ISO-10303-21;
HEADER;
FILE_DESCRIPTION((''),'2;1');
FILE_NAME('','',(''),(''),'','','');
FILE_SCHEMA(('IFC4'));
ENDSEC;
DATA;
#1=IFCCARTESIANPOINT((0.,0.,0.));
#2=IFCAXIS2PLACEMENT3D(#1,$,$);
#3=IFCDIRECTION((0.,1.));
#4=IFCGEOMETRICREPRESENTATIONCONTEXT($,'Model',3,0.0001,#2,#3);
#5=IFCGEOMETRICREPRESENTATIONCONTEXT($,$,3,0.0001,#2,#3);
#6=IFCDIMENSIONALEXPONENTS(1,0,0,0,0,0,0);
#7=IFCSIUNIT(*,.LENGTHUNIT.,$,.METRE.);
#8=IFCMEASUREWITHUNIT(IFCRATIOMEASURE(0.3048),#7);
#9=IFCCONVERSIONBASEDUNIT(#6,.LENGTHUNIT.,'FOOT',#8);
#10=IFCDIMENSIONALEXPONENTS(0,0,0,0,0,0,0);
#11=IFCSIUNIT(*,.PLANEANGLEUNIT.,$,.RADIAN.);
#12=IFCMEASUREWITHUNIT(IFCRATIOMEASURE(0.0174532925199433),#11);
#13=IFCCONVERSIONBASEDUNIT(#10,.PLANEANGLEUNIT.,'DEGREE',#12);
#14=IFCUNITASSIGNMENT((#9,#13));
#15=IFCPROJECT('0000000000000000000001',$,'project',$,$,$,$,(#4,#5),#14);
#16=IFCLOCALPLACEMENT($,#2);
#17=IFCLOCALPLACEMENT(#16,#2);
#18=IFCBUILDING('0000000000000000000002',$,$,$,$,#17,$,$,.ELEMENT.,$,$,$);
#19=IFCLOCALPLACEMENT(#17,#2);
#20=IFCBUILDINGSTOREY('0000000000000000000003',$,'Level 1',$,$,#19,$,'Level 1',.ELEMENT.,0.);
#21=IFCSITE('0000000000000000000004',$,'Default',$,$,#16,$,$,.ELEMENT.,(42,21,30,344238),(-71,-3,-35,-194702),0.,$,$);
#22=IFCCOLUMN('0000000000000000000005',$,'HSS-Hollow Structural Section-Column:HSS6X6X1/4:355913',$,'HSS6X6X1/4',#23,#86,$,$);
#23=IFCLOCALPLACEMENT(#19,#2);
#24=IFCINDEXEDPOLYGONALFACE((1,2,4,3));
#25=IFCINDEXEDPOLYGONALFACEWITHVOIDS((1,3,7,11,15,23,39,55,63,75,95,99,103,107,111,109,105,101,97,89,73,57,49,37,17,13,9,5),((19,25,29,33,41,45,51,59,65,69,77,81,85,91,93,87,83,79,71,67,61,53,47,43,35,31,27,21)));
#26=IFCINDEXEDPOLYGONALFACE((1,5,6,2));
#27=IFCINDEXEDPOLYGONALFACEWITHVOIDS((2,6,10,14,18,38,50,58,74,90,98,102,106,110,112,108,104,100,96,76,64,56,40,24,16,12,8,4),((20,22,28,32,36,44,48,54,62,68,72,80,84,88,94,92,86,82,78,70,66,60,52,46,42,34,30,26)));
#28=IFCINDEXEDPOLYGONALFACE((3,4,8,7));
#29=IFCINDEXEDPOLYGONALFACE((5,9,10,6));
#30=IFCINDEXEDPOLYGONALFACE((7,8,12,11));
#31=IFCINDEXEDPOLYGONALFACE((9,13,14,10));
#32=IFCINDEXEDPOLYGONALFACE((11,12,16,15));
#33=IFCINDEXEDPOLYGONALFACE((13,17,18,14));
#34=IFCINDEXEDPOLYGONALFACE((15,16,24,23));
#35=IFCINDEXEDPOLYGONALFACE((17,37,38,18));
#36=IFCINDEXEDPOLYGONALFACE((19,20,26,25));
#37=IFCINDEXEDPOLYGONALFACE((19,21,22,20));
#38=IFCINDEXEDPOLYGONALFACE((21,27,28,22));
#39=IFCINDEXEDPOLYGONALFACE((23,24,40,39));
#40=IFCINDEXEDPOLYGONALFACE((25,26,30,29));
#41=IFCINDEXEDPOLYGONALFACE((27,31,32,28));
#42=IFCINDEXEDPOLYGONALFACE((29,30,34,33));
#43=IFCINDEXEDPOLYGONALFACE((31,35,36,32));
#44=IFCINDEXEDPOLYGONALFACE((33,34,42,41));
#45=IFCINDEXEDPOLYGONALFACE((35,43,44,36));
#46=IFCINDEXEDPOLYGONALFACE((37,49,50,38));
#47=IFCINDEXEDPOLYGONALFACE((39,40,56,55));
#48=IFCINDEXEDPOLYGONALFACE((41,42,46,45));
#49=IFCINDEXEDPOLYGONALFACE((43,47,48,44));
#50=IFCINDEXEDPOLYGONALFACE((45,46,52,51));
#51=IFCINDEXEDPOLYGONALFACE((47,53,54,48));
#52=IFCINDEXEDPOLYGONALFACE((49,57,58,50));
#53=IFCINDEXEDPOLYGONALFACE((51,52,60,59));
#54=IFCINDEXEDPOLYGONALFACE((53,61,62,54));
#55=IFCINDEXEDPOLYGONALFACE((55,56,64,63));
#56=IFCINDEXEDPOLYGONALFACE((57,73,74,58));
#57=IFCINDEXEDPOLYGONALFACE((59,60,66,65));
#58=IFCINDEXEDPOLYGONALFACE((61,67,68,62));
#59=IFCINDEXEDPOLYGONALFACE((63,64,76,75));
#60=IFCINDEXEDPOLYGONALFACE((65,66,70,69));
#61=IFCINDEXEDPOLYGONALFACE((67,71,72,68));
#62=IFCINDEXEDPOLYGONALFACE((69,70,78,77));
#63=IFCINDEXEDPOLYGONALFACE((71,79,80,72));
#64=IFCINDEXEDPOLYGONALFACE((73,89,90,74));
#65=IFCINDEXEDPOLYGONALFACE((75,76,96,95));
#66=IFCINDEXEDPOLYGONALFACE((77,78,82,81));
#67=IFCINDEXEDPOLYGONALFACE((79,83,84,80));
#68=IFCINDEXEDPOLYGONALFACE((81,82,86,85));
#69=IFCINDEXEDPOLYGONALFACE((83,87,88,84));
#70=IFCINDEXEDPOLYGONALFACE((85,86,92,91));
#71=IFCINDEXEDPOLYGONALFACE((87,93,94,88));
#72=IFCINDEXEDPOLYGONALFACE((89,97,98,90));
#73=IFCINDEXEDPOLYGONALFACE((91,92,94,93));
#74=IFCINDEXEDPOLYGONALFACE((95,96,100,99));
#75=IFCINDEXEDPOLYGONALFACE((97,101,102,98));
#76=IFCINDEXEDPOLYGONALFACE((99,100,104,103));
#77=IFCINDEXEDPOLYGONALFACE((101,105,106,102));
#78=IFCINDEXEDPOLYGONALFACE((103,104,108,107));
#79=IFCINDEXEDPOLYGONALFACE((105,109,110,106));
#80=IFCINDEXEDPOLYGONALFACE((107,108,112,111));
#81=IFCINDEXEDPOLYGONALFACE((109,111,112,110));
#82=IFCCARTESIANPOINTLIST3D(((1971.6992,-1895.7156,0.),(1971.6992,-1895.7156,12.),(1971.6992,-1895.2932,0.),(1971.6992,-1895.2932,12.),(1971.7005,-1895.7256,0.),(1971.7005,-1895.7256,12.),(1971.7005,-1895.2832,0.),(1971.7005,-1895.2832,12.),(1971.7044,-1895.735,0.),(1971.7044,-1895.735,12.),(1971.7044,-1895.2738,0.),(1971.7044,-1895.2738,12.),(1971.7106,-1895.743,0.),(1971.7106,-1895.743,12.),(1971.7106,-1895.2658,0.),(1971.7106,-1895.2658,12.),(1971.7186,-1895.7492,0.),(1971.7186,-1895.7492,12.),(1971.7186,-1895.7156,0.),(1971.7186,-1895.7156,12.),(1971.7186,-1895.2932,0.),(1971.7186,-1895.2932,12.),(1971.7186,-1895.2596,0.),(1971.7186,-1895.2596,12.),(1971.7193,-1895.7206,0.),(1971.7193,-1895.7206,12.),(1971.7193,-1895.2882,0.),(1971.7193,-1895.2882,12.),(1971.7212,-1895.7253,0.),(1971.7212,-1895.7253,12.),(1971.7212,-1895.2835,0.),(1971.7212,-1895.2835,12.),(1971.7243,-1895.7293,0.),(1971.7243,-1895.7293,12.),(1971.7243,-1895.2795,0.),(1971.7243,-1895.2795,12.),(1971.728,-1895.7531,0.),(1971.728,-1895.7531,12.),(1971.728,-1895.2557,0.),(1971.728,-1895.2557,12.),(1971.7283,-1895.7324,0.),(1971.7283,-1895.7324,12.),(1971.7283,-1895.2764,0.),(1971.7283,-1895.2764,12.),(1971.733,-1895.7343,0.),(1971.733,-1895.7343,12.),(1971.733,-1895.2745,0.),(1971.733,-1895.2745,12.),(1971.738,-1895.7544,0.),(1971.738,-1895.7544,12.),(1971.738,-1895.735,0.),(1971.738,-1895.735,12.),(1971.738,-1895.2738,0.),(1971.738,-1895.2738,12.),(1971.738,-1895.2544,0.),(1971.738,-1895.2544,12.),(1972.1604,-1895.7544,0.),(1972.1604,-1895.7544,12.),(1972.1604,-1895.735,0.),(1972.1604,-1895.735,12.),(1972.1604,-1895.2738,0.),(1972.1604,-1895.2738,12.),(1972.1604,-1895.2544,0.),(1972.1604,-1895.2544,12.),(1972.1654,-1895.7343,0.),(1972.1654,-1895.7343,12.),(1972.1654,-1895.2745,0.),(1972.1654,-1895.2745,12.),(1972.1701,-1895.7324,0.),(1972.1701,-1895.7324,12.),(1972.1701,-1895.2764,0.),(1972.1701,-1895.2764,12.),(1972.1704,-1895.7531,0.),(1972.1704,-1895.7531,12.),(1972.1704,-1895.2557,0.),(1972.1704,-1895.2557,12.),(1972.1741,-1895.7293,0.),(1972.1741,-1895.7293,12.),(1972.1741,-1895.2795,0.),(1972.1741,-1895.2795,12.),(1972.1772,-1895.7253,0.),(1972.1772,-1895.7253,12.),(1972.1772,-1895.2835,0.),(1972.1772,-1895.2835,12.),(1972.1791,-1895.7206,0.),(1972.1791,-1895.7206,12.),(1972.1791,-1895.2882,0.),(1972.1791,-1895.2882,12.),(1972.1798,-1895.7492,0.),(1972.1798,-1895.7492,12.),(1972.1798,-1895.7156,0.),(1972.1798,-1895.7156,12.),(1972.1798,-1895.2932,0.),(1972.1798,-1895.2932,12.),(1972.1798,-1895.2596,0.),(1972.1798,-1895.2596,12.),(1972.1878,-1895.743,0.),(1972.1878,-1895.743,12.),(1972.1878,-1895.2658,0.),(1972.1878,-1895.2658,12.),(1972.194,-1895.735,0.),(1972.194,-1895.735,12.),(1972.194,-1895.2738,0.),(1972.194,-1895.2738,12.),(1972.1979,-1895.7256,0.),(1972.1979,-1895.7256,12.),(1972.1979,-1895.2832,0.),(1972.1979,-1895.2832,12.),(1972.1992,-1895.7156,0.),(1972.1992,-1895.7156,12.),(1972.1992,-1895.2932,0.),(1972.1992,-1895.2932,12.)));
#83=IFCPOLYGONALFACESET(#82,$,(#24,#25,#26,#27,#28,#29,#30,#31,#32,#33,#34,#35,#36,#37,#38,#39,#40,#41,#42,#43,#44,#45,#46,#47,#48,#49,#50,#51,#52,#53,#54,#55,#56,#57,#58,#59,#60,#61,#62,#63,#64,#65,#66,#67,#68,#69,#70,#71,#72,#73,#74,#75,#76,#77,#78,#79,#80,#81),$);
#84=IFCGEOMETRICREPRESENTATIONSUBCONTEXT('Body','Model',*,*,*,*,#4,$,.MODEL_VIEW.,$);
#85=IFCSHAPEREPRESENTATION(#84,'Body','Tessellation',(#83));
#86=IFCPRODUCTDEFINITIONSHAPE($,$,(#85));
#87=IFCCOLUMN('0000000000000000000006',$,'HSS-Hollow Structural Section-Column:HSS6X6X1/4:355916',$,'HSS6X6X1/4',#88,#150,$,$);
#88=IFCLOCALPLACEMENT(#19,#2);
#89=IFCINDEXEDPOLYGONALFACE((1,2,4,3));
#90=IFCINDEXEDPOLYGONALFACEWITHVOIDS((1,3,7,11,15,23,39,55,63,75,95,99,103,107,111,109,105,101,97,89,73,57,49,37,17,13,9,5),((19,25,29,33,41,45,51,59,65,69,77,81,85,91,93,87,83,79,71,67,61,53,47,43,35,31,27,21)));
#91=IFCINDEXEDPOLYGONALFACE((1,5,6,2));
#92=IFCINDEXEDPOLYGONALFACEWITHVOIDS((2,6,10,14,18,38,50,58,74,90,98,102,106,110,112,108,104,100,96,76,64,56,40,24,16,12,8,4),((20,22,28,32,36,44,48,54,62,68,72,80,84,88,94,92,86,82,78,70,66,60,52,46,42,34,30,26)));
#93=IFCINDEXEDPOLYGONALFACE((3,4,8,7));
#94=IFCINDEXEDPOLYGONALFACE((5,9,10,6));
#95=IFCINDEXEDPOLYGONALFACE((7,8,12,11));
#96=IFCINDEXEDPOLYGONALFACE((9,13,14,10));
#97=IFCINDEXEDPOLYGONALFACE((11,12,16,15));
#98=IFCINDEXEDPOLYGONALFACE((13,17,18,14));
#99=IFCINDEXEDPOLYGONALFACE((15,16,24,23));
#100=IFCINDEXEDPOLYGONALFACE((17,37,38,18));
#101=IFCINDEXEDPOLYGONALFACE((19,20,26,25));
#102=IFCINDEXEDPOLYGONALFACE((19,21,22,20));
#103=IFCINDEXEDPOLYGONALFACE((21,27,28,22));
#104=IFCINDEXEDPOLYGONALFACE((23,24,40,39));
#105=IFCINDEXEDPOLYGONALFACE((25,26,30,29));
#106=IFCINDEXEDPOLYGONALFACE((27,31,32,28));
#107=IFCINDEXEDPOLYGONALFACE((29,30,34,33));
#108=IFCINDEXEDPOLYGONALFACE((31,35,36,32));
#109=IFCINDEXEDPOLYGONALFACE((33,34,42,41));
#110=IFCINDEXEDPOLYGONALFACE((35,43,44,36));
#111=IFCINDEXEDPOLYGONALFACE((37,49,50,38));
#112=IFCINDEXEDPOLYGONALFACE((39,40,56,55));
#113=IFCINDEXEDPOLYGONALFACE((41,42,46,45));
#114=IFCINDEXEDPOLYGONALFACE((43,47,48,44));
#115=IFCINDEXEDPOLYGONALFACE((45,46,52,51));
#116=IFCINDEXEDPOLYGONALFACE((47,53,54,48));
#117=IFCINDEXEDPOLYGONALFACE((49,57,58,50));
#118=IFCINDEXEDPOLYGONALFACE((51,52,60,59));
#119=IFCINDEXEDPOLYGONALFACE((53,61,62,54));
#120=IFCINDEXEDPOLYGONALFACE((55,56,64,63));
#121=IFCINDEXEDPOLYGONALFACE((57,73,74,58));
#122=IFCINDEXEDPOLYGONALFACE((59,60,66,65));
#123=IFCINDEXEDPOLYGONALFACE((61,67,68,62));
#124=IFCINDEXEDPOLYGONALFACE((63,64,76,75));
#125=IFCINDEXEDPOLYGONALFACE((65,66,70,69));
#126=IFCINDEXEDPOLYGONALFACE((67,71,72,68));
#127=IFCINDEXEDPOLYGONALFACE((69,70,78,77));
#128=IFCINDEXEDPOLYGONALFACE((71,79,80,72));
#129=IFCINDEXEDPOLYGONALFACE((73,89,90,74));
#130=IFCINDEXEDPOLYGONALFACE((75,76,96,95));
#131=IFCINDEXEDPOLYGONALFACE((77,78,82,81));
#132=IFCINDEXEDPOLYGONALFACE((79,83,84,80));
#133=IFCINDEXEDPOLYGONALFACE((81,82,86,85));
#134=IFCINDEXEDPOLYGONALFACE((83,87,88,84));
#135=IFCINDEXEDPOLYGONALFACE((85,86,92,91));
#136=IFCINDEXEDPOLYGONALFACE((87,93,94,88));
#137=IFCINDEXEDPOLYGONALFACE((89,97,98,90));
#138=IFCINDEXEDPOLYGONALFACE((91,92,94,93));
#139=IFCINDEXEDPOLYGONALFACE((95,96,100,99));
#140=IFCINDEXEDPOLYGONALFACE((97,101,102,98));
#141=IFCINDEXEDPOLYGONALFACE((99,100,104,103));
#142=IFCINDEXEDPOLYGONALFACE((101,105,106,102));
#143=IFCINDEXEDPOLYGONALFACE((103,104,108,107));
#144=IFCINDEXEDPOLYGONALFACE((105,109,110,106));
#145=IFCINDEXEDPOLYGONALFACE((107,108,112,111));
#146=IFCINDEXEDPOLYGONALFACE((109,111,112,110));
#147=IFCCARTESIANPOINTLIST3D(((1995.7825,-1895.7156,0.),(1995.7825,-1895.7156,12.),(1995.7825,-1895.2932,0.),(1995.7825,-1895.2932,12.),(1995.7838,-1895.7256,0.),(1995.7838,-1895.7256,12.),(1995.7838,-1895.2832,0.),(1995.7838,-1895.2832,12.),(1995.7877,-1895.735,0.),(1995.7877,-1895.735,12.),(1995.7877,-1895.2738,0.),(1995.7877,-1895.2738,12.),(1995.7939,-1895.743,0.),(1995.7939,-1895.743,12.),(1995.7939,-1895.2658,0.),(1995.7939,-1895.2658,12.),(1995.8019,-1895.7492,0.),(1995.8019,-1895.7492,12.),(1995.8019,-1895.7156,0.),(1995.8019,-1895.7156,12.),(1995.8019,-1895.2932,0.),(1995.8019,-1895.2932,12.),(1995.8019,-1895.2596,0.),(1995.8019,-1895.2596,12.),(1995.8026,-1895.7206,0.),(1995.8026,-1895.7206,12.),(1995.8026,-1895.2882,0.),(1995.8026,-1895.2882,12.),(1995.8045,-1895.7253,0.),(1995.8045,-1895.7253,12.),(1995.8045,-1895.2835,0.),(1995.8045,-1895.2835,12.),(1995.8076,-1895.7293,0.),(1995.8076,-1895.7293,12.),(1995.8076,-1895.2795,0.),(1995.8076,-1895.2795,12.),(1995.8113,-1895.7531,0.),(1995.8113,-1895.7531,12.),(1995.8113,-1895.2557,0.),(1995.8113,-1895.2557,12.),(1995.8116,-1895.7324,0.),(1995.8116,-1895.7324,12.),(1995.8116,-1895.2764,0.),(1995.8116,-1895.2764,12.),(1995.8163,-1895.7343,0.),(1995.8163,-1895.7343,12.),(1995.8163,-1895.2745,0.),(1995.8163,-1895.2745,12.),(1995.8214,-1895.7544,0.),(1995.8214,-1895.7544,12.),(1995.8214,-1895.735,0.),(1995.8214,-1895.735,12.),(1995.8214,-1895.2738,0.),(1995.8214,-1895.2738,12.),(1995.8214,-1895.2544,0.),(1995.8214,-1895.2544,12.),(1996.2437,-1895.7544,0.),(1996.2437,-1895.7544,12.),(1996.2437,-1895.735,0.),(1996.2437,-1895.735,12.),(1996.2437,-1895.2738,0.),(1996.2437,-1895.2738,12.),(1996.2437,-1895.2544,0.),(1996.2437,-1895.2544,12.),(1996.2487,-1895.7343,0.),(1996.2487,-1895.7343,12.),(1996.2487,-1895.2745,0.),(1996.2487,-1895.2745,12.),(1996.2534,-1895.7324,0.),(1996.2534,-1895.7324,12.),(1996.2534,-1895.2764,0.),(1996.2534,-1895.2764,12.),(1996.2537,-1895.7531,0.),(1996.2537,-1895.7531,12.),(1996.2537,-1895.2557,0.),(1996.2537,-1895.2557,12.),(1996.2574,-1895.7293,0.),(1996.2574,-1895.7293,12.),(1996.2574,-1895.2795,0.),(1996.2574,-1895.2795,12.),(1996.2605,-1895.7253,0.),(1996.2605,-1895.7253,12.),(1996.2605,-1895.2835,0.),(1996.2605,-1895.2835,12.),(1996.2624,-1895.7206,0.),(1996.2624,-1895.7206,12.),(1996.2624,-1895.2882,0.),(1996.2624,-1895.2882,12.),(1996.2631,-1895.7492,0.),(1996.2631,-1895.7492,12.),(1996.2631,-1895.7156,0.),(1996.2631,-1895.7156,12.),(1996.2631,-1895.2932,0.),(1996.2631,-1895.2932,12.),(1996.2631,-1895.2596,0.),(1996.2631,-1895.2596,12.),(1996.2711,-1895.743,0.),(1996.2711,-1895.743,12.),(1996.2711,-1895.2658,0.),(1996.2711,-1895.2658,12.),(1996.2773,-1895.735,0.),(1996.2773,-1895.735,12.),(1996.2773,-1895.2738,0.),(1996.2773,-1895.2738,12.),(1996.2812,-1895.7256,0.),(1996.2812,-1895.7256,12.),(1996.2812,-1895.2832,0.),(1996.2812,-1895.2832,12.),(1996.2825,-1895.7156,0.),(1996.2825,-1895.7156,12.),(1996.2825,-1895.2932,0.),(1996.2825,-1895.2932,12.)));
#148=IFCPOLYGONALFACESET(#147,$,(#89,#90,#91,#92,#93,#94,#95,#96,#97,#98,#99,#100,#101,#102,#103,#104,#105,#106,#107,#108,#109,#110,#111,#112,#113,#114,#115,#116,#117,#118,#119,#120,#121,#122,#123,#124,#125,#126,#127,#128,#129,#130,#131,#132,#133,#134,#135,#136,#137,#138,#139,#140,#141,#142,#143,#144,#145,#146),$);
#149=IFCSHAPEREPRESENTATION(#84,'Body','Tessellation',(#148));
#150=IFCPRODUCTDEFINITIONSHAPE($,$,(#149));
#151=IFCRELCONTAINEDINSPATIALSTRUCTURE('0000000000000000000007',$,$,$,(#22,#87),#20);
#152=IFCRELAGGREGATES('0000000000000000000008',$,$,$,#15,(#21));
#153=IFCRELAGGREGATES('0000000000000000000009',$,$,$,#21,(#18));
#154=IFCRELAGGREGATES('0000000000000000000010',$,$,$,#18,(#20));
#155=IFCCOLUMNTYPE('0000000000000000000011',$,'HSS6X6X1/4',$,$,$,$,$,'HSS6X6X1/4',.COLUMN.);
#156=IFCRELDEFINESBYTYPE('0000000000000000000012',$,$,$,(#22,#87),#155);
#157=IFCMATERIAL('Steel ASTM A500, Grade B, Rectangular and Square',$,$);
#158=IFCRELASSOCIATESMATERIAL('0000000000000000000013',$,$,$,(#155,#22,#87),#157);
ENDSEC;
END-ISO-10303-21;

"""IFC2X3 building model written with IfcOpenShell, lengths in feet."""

from ifc_helpers import new_model, entity, si_unit, converted_unit, direction, frame, frame_2d, origin, place, context, subcontext, project, spatial, polyline, circle_curve, parameter, trimmed, segment, composite_curve, outline, extrude, source, transform, mapped, material, type_object, type_shapes, element, save


model = new_model("IFC2X3")

# Units and contexts
model_context = context("Model", 3, precision=0.0001, world=origin(), true_north=direction((0.0, 1.0)))
context_of_model = context(None, 3, precision=0.0001, world=origin(), true_north=direction((0.0, 1.0)))
body_context = subcontext(model_context, "Body", "Model", "MODEL_VIEW")
ifc_project = project(units=[converted_unit("LENGTHUNIT", "FOOT", entity("IfcRatioMeasure", 0.3048), si_unit("LENGTHUNIT", "METRE"), dimensions=[1, 0, 0, 0, 0, 0, 0]), converted_unit("PLANEANGLEUNIT", "DEGREE", entity("IfcRatioMeasure", 0.0174532925199433), si_unit("PLANEANGLEUNIT", "RADIAN"), dimensions=[0, 0, 0, 0, 0, 0, 0])], contexts=[model_context, context_of_model])

# Site, building, storey
site_placement = place(None, origin())
site = spatial("IfcSite", under=ifc_project, at=site_placement, Name="Default", CompositionType="ELEMENT", RefLatitude=(42, 21, 30, 344238), RefLongitude=(-71, -3, -35, -194702), RefElevation=0.0)
building_placement = place(site_placement, origin())
building = spatial("IfcBuilding", under=site, at=building_placement, CompositionType="ELEMENT")
storey_placement = place(building_placement, origin())
storey = spatial("IfcBuildingStorey", under=building, at=storey_placement, Name="Level 1", LongName="Level 1", CompositionType="ELEMENT", Elevation=0.0)

# Columns
ifc_material_1 = material(Name="Steel ASTM A500, Grade B, Rectangular and Square")
column_type = type_object("IfcColumnType", Name="HSS6X6X1/4", ElementType="HSS6X6X1/4", PredefinedType="COLUMN", material=ifc_material_1)
shared_shape = source(origin(), body_context, "Body", "SweptSolid", [
    extrude(outline(composite_curve([segment(polyline([(-0.2112, -0.25), (0.2112, -0.25)]), True, "CONTINUOUS"), segment(trimmed(circle_curve(frame_2d((0.2112, -0.2112), x_axis=(-1.0, 0.0)), 0.0388), [parameter(90.0)], [parameter(180.0)], True, "PARAMETER"), True, "CONTINUOUS"), segment(polyline([(0.25, -0.2112), (0.25, 0.2112)]), True, "CONTINUOUS"), segment(trimmed(circle_curve(frame_2d((0.2112, 0.2112), x_axis=(-1.0, 0.0)), 0.0388), [parameter(180.0)], [parameter(270.0)], True, "PARAMETER"), True, "CONTINUOUS"), segment(polyline([(0.2112, 0.25), (-0.2112, 0.25)]), True, "CONTINUOUS"), segment(trimmed(circle_curve(frame_2d((-0.2112, 0.2112), x_axis=(-1.0, 0.0)), 0.0388), [parameter(270.0)], [parameter(360.0)], True, "PARAMETER"), True, "CONTINUOUS"), segment(polyline([(-0.25, 0.2112), (-0.25, -0.2112)]), True, "CONTINUOUS"), segment(trimmed(circle_curve(frame_2d((-0.2112, -0.2112), x_axis=(-1.0, 0.0)), 0.0388), [parameter(360.0)], [parameter(90.0)], True, "PARAMETER"), True, "CONTINUOUS")], self_intersect=False), holes=[composite_curve([segment(trimmed(circle_curve(frame_2d((-0.2112, -0.2112), x_axis=(-1.0, 0.0)), 0.0194), [parameter(0.0)], [parameter(90.0)], True, "PARAMETER"), False, "CONTINUOUS"), segment(polyline([(-0.2306, -0.2112), (-0.2306, 0.2112)]), True, "CONTINUOUS"), segment(trimmed(circle_curve(frame_2d((-0.2112, 0.2112), x_axis=(-1.0, 0.0)), 0.0194), [parameter(270.0)], [parameter(360.0)], True, "PARAMETER"), False, "CONTINUOUS"), segment(polyline([(-0.2112, 0.2306), (0.2112, 0.2306)]), True, "CONTINUOUS"), segment(trimmed(circle_curve(frame_2d((0.2112, 0.2112), x_axis=(-1.0, 0.0)), 0.0194), [parameter(180.0)], [parameter(270.0)], True, "PARAMETER"), False, "CONTINUOUS"), segment(polyline([(0.2306, 0.2112), (0.2306, -0.2112)]), True, "CONTINUOUS"), segment(trimmed(circle_curve(frame_2d((0.2112, -0.2112), x_axis=(-1.0, 0.0)), 0.0194), [parameter(90.0)], [parameter(180.0)], True, "PARAMETER"), False, "CONTINUOUS"), segment(polyline([(0.2112, -0.2306), (-0.2112, -0.2306)]), True, "CONTINUOUS")], self_intersect=False)]), frame((0.0, 0.0, 0.0), z_axis=(0.0, 0.0, 1.0), x_axis=(-1.0, 0.0, 0.0)), (0.0, 0.0, 1.0), 12.0),
])
type_shapes(column_type, [shared_shape])
for number, where, z_axis, x_axis, name in (
    (1, (1971.9492, -1895.5044, 0.0), (0.0, 0.0, 1.0), (-1.0, 0.0, 0.0), "HSS-Hollow Structural Section-Column:HSS6X6X1/4:355913"),
    (2, (1996.0325, -1895.5044, 0.0), (0.0, 0.0, 1.0), (-1.0, 0.0, 0.0), "HSS-Hollow Structural Section-Column:HSS6X6X1/4:355916"),
):
    element("IfcColumn", number, at=place(storey_placement, frame(where, z_axis=z_axis, x_axis=x_axis)), inside=storey, type_object=column_type, material=ifc_material_1, Name=name, ObjectType="HSS6X6X1/4", context=body_context, shape_type="MappedRepresentation", body=[
        mapped(shared_shape, transform((0.0, 0.0, 0.0), scale=1.0)),
    ])

save(model, "model.ifc")
